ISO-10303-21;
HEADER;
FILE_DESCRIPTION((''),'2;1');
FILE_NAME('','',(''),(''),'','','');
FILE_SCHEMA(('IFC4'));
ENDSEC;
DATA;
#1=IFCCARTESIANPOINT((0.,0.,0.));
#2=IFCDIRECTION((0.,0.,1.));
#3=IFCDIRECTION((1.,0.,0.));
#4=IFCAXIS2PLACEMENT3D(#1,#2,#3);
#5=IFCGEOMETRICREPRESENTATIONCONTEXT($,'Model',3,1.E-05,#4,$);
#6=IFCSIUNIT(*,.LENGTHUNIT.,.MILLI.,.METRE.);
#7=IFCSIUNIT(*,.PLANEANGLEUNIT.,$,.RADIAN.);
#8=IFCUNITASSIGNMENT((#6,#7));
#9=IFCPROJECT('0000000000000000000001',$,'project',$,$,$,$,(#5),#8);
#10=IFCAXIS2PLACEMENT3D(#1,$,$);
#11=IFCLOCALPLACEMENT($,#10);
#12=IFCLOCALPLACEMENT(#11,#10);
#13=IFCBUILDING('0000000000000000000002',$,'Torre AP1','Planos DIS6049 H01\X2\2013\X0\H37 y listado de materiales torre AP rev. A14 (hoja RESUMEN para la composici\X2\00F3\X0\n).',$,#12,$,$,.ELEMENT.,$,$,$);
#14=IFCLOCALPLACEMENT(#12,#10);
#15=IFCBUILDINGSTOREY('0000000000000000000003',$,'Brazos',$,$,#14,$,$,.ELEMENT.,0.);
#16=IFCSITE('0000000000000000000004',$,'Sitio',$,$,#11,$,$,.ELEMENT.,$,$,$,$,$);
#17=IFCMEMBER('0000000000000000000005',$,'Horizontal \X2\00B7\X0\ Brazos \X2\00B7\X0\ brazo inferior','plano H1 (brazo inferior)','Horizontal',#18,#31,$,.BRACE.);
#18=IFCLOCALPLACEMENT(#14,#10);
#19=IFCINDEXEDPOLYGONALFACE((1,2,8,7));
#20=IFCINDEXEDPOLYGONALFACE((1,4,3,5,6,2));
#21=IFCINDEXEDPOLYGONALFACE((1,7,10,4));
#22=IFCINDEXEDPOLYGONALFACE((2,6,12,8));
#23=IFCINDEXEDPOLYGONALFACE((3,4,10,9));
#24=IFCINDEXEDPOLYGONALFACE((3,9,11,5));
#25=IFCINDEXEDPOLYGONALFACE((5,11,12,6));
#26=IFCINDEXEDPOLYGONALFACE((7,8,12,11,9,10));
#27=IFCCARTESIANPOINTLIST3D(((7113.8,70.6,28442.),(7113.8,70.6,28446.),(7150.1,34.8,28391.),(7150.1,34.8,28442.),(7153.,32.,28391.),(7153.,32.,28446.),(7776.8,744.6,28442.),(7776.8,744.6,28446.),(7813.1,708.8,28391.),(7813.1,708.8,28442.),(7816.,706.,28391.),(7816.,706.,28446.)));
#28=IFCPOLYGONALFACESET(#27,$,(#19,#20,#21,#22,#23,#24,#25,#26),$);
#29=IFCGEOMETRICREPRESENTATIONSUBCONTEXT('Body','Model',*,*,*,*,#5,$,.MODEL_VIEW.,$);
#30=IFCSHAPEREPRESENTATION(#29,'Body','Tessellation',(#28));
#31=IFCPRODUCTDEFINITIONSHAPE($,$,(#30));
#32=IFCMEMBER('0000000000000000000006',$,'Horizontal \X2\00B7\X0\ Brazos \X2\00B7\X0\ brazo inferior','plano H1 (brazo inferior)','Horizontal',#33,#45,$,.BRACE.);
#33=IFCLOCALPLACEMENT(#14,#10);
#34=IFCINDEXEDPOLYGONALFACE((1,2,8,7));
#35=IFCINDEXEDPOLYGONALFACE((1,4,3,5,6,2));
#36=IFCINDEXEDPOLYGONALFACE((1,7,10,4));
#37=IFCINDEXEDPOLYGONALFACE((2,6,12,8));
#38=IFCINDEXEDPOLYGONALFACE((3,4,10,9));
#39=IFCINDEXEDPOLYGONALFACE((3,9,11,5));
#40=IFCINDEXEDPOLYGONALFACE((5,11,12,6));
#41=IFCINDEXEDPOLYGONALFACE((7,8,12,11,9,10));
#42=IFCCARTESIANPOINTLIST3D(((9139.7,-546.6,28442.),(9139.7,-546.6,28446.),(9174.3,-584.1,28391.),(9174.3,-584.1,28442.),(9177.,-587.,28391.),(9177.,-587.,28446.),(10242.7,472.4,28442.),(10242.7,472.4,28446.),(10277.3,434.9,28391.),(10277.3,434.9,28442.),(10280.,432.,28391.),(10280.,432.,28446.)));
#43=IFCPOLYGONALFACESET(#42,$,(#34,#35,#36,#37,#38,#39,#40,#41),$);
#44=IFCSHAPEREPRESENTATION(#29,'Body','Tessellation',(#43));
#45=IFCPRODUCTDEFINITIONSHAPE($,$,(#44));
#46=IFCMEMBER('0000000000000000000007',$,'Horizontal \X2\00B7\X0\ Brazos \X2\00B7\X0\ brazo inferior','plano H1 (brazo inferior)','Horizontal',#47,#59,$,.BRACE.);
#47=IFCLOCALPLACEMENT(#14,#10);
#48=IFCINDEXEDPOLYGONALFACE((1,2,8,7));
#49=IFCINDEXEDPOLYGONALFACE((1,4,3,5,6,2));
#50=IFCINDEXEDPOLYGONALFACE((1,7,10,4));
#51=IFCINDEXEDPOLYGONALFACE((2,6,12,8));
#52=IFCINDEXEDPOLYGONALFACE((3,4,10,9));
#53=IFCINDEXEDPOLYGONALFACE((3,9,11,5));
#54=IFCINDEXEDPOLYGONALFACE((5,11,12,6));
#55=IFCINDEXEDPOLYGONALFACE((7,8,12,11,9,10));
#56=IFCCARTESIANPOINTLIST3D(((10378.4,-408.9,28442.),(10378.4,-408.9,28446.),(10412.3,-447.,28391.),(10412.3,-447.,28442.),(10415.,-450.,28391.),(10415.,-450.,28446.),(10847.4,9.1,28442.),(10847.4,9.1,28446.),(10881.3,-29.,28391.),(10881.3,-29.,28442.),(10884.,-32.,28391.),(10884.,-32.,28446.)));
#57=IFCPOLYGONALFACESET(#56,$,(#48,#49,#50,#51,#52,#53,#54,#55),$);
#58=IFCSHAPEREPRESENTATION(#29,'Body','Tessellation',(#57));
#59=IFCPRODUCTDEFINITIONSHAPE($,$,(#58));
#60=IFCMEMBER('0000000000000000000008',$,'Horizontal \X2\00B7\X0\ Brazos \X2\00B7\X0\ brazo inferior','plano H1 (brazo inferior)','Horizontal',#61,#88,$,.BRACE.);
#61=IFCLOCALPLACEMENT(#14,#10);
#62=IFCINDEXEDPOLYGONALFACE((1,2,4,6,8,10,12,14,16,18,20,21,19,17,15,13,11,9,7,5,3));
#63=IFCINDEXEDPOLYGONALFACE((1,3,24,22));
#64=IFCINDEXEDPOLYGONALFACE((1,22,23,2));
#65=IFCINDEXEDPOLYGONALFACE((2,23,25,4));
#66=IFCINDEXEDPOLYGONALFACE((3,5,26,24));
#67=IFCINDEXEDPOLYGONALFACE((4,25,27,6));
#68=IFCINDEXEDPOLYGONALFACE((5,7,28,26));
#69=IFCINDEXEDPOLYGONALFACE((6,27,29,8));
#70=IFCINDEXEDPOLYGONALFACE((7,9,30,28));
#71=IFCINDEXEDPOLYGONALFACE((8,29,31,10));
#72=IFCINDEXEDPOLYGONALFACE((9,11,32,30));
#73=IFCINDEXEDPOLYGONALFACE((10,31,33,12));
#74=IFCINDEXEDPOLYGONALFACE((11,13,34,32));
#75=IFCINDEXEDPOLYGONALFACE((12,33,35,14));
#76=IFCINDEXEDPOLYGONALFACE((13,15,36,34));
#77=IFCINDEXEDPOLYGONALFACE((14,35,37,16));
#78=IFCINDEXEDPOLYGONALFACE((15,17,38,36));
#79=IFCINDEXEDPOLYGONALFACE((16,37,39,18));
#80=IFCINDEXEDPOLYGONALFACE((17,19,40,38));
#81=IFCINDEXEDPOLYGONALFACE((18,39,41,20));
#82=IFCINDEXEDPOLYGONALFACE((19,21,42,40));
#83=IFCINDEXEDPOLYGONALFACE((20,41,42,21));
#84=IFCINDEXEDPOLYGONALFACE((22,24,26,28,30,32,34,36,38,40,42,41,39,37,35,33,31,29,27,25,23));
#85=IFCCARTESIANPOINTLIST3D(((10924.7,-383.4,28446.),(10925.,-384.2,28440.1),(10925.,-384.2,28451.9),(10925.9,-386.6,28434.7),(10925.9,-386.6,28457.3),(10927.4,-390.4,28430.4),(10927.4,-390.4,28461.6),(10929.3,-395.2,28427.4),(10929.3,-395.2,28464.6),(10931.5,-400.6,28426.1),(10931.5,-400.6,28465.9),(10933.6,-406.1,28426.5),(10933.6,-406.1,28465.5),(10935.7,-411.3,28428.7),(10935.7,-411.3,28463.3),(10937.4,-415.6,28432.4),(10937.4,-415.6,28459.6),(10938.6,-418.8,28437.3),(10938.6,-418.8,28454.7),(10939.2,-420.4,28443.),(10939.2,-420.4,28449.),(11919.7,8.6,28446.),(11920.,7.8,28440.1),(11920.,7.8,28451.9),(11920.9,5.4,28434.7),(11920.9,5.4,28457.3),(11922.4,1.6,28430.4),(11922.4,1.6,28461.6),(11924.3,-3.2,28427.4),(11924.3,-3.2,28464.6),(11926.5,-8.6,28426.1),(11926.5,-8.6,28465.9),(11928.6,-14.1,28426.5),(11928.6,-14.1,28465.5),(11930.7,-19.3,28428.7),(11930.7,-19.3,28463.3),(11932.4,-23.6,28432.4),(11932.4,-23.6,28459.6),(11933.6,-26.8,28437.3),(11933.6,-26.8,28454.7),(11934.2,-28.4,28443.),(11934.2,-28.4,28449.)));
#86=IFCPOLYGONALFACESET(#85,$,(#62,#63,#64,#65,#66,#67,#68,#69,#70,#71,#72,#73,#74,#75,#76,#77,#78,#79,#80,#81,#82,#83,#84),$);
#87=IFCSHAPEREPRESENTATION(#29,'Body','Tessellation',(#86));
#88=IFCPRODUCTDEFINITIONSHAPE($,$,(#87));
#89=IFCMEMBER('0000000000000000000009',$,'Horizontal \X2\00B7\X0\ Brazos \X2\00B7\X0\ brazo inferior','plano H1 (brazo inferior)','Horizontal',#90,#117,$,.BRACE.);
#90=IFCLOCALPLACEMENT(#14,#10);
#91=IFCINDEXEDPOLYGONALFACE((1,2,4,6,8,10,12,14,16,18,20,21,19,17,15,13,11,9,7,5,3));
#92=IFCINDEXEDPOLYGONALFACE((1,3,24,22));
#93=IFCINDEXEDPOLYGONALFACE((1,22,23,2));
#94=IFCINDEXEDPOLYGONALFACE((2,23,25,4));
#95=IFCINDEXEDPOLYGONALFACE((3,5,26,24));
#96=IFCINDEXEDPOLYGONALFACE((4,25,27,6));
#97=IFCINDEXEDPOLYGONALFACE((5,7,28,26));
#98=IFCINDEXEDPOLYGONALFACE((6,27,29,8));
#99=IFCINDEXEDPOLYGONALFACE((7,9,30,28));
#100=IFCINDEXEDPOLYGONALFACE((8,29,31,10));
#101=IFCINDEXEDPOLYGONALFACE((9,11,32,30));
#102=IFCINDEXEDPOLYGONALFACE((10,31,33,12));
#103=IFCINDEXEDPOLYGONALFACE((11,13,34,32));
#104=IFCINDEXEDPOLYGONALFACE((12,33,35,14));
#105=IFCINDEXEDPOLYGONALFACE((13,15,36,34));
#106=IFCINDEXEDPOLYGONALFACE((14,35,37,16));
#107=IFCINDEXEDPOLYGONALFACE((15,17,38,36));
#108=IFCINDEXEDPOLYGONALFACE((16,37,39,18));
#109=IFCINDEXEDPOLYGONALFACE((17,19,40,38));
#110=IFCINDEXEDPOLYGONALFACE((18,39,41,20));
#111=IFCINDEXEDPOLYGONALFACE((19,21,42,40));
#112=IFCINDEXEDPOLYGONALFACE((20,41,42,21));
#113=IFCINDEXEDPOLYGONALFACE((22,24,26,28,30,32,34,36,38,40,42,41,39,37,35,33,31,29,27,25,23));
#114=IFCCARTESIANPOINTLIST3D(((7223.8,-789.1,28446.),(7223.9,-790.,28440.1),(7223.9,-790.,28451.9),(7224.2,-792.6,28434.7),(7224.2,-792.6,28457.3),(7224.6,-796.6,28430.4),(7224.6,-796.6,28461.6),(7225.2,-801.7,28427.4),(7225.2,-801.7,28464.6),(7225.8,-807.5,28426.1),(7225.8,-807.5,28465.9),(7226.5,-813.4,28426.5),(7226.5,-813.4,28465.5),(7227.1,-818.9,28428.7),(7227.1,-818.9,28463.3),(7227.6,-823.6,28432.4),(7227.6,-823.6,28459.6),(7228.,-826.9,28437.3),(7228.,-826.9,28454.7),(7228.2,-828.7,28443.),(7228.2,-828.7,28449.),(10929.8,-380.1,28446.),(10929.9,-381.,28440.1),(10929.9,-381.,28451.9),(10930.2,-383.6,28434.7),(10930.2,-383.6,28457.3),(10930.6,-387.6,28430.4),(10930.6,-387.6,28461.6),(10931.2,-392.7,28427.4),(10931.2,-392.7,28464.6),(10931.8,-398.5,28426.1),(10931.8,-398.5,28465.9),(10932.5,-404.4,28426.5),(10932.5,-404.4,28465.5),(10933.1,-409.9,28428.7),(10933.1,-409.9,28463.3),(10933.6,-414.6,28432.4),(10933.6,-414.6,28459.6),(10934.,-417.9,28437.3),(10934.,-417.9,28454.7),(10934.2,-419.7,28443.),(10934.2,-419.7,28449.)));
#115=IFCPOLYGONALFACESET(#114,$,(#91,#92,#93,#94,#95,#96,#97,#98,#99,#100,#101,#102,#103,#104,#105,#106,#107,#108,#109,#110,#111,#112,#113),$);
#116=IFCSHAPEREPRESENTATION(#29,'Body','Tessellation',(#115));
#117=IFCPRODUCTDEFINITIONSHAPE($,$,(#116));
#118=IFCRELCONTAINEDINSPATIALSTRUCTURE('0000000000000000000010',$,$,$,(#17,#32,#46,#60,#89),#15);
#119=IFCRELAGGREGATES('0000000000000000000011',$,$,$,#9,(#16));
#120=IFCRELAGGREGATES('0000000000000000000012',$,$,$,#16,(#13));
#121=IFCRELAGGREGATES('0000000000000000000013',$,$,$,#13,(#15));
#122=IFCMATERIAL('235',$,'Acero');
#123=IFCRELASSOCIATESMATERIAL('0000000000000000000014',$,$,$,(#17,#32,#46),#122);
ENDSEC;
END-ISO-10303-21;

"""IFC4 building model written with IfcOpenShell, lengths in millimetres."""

from ifc_helpers import new_model, si_unit, frame, frame_2d, origin, origin_with_axes, place, context, subcontext, project, spatial, circle, l_section, extrude, material, element, save


model = new_model("IFC4")

# Units and contexts
model_context = context("Model", 3, precision=1e-05, world=origin_with_axes())
body_context = subcontext(model_context, "Body", "Model", "MODEL_VIEW")
ifc_project = project(units=[si_unit("LENGTHUNIT", "METRE", prefix="MILLI"), si_unit("PLANEANGLEUNIT", "RADIAN")], contexts=[model_context])

# Site, building, storey
site_placement = place(None, origin())
site = spatial("IfcSite", under=ifc_project, at=site_placement, Name="Sitio", CompositionType="ELEMENT")
building_placement = place(site_placement, origin())
building = spatial("IfcBuilding", under=site, at=building_placement, Name="Torre AP1", Description="Planos DIS6049 H01–H37 y listado de materiales torre AP rev. A14 (hoja RESUMEN para la composición).", CompositionType="ELEMENT")
storey_placement = place(building_placement, origin())
storey = spatial("IfcBuildingStorey", under=building, at=storey_placement, Name="Brazos", CompositionType="ELEMENT", Elevation=0.0)

# Members
ifc_material_1 = material(Name="235", Category="Acero")
member_1_placement = place(storey_placement, frame((7816.0, 706.0, 28446.0), z_axis=(-0.701265, -0.7129, 0.0), x_axis=(-0.7129, 0.701265, 0.0)))
element("IfcMember", 1, at=member_1_placement, inside=storey, material=ifc_material_1, Name="Horizontal · Brazos · brazo inferior", Description="plano H1 (brazo inferior)", ObjectType="Horizontal", PredefinedType="BRACE", context=body_context, shape_type="SweptSolid", body=[
    extrude(l_section(Depth=55.0, Width=55.0, Thickness=4.0, at=frame_2d((27.5, 27.5))), None, (0.0, 0.0, 1.0), 945.4),
])
member_2_placement = place(storey_placement, frame((10280.0, 432.0, 28446.0), z_axis=(-0.734523, -0.678584, 0.0), x_axis=(-0.678584, 0.734523, 0.0)))
element("IfcMember", 2, at=member_2_placement, inside=storey, material=ifc_material_1, Name="Horizontal · Brazos · brazo inferior", Description="plano H1 (brazo inferior)", ObjectType="Horizontal", PredefinedType="BRACE", context=body_context, shape_type="SweptSolid", body=[
    extrude(l_section(Depth=55.0, Width=55.0, Thickness=4.0, at=frame_2d((27.5, 27.5))), None, (0.0, 0.0, 1.0), 1501.7),
])
member_3_placement = place(storey_placement, frame((10884.0, -32.0, 28446.0), z_axis=(-0.74653, -0.665351, 0.0), x_axis=(-0.665351, 0.74653, 0.0)))
element("IfcMember", 3, at=member_3_placement, inside=storey, material=ifc_material_1, Name="Horizontal · Brazos · brazo inferior", Description="plano H1 (brazo inferior)", ObjectType="Horizontal", PredefinedType="BRACE", context=body_context, shape_type="SweptSolid", body=[
    extrude(l_section(Depth=55.0, Width=55.0, Thickness=4.0, at=frame_2d((27.5, 27.5))), None, (0.0, 0.0, 1.0), 628.2),
])
member_4_placement = place(storey_placement, frame((11927.0, -10.0, 28446.0), z_axis=(-0.930399, -0.366549, 0.0), x_axis=(-0.366549, 0.930399, 0.0)))
element("IfcMember", 4, at=member_4_placement, inside=storey, Name="Horizontal · Brazos · brazo inferior", Description="plano H1 (brazo inferior)", ObjectType="Horizontal", PredefinedType="BRACE", context=body_context, shape_type="SweptSolid", body=[
    extrude(circle(Radius=20.0), None, (0.0, 0.0, 1.0), 1069.4),
])
member_5_placement = place(storey_placement, frame((10932.0, -400.0, 28446.0), z_axis=(-0.993965, -0.109696, 0.0), x_axis=(-0.109696, 0.993965, 0.0)))
element("IfcMember", 5, at=member_5_placement, inside=storey, Name="Horizontal · Brazos · brazo inferior", Description="plano H1 (brazo inferior)", ObjectType="Horizontal", PredefinedType="BRACE", context=body_context, shape_type="SweptSolid", body=[
    extrude(circle(Radius=20.0), None, (0.0, 0.0, 1.0), 3728.5),
])

save(model, "model.ifc")
